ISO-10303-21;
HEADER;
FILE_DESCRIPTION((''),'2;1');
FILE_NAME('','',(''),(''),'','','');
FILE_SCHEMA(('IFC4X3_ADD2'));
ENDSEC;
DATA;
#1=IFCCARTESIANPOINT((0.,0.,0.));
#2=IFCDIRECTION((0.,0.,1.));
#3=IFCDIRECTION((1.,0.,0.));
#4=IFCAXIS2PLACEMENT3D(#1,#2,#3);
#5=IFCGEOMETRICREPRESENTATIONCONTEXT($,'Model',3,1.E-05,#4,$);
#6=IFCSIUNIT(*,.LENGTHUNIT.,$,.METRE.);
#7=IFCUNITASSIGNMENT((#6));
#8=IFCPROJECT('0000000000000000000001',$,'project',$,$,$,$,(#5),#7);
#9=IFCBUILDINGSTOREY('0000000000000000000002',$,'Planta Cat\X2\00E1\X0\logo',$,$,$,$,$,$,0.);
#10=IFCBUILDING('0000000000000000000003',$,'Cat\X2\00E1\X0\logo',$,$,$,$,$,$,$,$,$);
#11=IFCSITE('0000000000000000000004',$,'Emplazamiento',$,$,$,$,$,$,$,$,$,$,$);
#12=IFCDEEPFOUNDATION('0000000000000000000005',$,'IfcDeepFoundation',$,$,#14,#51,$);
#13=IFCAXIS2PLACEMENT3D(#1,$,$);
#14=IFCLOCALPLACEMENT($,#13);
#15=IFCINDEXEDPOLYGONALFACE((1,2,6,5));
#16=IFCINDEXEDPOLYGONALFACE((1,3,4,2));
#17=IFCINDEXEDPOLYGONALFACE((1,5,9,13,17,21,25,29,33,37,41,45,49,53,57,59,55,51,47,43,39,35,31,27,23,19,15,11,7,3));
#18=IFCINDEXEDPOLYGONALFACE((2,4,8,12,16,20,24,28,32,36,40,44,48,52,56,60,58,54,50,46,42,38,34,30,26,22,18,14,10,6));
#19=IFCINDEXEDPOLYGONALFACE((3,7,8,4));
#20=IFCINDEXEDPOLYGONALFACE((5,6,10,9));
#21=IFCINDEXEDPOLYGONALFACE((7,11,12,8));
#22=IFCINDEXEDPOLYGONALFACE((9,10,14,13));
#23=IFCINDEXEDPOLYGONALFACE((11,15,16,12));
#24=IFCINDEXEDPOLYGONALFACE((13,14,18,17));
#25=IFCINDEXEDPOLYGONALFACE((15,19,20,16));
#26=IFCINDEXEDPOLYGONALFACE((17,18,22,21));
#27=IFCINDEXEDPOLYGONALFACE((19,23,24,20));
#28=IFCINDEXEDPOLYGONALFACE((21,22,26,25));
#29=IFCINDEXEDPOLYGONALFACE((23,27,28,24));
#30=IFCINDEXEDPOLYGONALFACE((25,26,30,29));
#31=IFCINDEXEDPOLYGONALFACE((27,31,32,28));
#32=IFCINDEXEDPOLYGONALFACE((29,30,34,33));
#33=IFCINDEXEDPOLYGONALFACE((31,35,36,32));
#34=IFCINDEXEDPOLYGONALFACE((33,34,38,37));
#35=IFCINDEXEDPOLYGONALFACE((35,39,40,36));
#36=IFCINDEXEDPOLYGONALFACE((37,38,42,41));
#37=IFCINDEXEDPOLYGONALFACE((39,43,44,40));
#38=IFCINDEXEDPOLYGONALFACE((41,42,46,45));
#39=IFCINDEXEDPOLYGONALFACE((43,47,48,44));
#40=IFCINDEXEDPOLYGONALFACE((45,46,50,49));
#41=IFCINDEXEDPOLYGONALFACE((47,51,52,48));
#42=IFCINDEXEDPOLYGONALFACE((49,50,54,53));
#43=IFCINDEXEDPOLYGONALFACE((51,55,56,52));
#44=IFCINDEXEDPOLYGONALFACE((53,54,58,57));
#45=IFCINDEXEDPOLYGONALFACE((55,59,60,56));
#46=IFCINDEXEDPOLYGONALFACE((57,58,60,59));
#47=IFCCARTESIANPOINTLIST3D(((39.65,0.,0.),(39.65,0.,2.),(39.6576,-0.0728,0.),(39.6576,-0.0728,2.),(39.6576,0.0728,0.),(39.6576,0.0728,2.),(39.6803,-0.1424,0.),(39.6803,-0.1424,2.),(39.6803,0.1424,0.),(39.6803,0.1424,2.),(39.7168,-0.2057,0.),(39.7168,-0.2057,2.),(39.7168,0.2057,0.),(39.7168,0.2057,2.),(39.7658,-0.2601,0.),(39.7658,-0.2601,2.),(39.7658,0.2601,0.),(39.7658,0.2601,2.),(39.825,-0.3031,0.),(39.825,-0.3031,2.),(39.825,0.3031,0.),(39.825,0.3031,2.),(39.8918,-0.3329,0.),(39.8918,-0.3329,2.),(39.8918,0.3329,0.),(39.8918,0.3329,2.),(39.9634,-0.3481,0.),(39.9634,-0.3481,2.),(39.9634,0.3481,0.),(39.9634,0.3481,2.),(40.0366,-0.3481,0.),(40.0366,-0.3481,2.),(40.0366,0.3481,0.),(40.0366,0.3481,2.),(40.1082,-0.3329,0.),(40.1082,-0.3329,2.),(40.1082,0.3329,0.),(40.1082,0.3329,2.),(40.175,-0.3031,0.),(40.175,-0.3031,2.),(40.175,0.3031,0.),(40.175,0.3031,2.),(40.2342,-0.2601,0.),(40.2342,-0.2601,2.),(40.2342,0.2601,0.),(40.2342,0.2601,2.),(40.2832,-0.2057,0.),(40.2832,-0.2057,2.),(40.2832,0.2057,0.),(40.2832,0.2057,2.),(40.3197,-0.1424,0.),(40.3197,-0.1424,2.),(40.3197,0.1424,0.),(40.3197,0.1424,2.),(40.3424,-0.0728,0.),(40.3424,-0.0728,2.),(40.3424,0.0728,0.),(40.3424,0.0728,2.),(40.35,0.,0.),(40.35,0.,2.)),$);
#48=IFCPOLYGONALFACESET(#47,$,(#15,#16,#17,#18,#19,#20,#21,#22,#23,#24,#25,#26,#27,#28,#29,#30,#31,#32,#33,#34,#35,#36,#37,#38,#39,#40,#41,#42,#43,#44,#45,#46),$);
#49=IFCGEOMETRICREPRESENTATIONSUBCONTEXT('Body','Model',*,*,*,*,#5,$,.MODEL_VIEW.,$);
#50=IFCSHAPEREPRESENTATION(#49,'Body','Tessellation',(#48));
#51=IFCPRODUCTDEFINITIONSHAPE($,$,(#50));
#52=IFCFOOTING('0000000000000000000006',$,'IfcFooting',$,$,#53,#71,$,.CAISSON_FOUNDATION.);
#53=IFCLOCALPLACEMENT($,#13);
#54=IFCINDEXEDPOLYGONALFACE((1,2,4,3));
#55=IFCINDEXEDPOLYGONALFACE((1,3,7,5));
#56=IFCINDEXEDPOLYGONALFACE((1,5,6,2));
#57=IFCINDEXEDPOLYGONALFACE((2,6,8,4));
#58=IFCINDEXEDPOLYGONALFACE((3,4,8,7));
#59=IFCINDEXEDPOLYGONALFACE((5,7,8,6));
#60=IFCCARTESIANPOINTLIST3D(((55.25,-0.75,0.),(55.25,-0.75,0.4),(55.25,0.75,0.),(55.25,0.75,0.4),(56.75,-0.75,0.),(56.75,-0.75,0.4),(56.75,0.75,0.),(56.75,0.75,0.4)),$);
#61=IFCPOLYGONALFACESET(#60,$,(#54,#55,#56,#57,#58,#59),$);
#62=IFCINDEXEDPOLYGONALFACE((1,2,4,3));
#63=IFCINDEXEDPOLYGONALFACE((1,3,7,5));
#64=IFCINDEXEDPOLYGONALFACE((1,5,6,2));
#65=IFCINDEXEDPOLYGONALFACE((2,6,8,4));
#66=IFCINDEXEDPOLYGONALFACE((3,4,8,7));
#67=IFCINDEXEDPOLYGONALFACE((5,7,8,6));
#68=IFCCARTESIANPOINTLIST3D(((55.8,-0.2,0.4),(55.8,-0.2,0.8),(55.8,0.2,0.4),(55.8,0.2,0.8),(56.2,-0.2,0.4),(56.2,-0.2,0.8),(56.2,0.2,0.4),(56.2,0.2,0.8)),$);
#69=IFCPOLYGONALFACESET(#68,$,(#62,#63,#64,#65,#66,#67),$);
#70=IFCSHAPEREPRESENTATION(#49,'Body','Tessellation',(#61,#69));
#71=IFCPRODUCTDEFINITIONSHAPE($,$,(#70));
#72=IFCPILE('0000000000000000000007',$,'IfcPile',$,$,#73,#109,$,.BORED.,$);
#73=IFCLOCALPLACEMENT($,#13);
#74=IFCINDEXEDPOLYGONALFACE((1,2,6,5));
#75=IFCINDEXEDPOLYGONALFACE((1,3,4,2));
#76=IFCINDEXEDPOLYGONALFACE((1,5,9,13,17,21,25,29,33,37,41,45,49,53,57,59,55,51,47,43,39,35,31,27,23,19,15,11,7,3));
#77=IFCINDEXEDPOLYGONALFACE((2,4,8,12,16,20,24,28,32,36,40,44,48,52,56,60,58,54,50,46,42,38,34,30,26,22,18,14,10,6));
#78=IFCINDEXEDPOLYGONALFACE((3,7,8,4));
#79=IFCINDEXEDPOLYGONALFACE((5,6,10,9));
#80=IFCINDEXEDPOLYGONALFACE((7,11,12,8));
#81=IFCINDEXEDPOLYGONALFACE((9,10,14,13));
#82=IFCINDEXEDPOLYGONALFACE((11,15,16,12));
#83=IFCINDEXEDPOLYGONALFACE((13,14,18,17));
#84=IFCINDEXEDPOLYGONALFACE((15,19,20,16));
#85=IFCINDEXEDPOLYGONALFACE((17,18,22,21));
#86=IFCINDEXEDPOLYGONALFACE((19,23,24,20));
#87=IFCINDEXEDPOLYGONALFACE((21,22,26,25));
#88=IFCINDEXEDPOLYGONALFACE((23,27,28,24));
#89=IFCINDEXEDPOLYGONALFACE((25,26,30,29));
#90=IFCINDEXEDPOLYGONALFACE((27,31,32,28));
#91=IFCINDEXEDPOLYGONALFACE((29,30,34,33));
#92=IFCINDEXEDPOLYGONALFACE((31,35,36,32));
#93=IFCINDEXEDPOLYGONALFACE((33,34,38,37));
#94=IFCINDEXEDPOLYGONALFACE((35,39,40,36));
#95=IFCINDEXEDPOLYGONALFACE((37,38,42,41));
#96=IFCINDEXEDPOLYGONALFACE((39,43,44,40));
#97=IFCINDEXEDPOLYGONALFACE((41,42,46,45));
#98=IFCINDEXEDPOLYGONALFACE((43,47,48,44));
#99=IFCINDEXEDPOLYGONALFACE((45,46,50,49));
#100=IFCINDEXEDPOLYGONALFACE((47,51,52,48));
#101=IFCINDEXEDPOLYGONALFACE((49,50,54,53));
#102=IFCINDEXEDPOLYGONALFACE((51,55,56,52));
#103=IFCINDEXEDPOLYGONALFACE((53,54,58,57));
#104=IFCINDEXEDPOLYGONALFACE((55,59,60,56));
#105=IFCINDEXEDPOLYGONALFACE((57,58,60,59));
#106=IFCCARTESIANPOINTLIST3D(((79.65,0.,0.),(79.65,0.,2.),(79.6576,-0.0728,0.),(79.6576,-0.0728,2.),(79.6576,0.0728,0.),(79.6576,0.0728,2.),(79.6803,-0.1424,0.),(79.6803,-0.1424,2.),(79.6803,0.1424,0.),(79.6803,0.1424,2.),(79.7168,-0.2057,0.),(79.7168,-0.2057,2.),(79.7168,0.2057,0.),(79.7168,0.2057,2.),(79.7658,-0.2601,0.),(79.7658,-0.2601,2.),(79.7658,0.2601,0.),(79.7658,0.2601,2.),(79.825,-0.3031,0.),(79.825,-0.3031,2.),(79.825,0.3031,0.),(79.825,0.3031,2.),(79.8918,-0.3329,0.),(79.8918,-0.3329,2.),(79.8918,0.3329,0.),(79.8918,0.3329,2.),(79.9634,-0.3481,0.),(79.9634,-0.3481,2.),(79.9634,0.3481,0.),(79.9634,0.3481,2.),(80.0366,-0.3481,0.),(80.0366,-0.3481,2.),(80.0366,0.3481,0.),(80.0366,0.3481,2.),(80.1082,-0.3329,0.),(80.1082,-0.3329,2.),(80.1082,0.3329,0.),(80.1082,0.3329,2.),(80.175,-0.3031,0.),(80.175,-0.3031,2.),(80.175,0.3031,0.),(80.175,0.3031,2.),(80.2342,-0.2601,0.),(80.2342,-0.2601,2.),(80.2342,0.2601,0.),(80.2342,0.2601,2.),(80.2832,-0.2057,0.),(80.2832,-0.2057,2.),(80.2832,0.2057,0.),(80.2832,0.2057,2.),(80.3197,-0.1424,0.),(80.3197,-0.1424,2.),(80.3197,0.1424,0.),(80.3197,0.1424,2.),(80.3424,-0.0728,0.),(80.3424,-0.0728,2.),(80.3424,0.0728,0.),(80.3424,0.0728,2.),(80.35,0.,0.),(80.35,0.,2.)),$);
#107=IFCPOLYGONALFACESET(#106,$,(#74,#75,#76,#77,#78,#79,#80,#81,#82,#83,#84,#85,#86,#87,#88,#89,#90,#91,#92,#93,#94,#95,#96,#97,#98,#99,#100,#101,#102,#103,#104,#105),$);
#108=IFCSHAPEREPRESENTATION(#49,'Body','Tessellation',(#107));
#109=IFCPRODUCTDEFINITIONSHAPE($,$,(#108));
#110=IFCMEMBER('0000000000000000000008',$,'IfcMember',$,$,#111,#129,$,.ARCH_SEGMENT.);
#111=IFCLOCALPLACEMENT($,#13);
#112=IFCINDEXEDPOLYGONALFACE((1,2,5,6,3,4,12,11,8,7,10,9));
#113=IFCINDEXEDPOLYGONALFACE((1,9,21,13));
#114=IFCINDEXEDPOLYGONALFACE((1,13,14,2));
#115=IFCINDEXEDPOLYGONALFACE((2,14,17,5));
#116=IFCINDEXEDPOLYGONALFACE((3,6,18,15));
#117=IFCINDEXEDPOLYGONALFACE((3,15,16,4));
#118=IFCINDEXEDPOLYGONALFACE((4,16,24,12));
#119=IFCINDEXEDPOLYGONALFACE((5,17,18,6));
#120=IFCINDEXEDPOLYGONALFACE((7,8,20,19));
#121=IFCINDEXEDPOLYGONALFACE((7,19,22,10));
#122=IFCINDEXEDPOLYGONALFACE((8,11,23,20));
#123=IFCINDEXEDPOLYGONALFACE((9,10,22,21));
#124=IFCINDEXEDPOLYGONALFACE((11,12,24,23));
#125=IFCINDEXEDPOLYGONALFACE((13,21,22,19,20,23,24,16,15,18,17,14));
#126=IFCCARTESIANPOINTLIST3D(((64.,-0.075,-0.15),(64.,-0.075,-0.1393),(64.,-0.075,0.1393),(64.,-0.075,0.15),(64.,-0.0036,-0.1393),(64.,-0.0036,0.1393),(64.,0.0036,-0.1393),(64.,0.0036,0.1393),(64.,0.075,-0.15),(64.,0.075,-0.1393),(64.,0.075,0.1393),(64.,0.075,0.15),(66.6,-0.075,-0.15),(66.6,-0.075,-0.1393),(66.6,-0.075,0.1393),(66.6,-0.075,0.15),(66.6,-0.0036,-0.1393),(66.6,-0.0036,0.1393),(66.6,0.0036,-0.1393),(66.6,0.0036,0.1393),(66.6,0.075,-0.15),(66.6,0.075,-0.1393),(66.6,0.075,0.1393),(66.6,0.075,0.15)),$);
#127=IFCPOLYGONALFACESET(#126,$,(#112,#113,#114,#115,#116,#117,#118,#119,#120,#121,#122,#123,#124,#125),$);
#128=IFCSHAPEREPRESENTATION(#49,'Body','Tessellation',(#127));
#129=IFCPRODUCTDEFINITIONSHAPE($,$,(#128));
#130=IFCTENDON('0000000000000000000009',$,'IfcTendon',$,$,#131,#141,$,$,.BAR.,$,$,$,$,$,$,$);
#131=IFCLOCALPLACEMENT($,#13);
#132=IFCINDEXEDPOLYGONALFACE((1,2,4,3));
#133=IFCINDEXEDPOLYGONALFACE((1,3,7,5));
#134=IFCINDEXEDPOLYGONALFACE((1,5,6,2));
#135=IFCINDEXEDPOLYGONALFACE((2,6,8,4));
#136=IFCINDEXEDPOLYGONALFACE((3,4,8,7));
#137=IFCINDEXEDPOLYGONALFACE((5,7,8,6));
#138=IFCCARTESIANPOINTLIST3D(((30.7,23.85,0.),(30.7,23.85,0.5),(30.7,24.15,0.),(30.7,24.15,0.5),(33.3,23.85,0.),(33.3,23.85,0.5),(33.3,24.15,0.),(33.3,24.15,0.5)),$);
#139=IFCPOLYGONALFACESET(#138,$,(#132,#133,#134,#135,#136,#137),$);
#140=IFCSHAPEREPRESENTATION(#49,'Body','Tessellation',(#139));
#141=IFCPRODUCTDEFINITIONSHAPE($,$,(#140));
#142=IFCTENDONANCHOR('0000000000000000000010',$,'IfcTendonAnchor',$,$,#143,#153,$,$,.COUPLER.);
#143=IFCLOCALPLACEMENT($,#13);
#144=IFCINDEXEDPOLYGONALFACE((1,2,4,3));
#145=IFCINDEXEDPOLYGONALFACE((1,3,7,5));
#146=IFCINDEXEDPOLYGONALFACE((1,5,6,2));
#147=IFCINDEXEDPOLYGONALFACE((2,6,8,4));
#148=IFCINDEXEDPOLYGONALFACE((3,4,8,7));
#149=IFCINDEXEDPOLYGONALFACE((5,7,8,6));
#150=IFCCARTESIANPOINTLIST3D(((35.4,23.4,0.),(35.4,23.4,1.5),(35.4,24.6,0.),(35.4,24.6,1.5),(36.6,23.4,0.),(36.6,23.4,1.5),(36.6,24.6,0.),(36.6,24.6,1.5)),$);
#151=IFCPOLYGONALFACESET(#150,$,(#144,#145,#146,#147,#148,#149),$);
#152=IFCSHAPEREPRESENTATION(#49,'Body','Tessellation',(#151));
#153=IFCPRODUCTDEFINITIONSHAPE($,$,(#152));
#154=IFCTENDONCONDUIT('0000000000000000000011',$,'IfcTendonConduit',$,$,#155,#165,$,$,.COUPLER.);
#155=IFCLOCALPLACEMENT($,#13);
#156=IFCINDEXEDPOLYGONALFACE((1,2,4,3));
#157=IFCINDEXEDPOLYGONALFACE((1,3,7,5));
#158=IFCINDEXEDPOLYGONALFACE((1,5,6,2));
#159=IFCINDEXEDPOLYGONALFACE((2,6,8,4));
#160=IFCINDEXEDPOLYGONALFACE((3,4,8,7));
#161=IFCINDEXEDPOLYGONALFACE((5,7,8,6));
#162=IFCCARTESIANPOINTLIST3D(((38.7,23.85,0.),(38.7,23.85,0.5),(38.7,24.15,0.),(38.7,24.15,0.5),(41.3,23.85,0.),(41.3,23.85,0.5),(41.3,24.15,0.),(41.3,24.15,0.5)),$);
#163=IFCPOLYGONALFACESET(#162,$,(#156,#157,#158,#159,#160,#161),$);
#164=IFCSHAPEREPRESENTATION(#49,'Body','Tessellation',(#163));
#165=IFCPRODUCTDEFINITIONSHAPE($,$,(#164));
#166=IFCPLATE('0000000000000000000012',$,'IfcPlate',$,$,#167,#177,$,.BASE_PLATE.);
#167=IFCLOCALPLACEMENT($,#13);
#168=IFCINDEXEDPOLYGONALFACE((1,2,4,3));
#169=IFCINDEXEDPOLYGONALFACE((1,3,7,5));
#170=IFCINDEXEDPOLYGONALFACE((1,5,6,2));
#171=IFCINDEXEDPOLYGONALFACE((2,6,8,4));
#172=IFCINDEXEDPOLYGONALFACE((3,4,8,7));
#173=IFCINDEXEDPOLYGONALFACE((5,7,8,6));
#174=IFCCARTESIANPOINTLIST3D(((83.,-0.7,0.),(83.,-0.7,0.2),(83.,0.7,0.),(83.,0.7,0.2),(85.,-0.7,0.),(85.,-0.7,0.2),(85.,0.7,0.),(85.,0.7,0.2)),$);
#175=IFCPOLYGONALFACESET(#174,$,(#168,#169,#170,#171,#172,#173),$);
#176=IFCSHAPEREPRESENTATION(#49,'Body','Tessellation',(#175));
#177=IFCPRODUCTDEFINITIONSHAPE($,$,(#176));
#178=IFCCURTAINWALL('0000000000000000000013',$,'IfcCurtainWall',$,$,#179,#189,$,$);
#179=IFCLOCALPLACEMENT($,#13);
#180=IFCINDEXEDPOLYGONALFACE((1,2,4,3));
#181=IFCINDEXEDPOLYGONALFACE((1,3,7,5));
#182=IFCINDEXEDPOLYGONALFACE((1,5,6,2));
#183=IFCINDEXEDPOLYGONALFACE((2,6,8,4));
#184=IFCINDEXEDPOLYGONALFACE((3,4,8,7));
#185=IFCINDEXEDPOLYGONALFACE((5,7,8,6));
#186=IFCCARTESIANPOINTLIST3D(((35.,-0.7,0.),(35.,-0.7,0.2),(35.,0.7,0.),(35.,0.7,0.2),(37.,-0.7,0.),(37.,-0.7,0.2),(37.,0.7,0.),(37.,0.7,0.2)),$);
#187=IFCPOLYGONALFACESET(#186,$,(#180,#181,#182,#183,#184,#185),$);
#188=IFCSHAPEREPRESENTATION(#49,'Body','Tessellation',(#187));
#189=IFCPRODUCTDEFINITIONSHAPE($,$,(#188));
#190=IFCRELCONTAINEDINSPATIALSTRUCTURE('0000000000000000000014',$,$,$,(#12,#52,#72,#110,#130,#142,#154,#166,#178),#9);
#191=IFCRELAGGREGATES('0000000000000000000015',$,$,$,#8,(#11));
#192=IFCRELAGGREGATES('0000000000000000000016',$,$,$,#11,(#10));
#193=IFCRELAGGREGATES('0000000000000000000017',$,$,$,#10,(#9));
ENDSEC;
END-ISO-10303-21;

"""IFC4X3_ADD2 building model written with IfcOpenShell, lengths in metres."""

from ifc_helpers import new_model, si_unit, frame, origin, origin_with_axes, origin_2d, place, context, subcontext, project, spatial, rectangle, circle, i_section, extrude, element, save


model = new_model("IFC4X3_ADD2")

# Units and contexts
model_context = context("Model", 3, precision=1e-05, world=origin_with_axes())
body_context = subcontext(model_context, "Body", "Model", "MODEL_VIEW")
ifc_project = project(units=[si_unit("LENGTHUNIT", "METRE")], contexts=[model_context])

# Site, building, storey
site = spatial("IfcSite", under=ifc_project, Name="Emplazamiento")
building = spatial("IfcBuilding", under=site, Name="Catálogo")
storey = spatial("IfcBuildingStorey", under=building, Name="Planta Catálogo", Elevation=0.0)

# Deep foundation
deep_foundation_placement = place(None, frame((40.0, 0.0, 0.0), z_axis=(0.0, 0.0, 1.0), x_axis=(1.0, 0.0, 0.0)))
element("IfcDeepFoundation", 1, at=deep_foundation_placement, inside=storey, Name="IfcDeepFoundation", context=body_context, shape_type="SweptSolid", body=[
    extrude(circle(Radius=0.35, at=origin_2d()), origin(), (0.0, 0.0, 1.0), 2.0),
])

# Footing
footing_placement = place(None, frame((56.0, 0.0, 0.0), z_axis=(0.0, 0.0, 1.0), x_axis=(1.0, 0.0, 0.0)))
element("IfcFooting", 2, at=footing_placement, inside=storey, Name="IfcFooting", PredefinedType="CAISSON_FOUNDATION", context=body_context, shape_type="SweptSolid", body=[
    extrude(rectangle(XDim=1.5, YDim=1.5, at=origin_2d()), origin(), (0.0, 0.0, 1.0), 0.4),
    extrude(rectangle(XDim=0.4, YDim=0.4, at=origin_2d()), frame((0.0, 0.0, 0.4)), (0.0, 0.0, 1.0), 0.4),
])

# Pile
pile_placement = place(None, frame((80.0, 0.0, 0.0), z_axis=(0.0, 0.0, 1.0), x_axis=(1.0, 0.0, 0.0)))
element("IfcPile", 3, at=pile_placement, inside=storey, Name="IfcPile", PredefinedType="BORED", context=body_context, shape_type="SweptSolid", body=[
    extrude(circle(Radius=0.35, at=origin_2d()), origin(), (0.0, 0.0, 1.0), 2.0),
])

# Member
member_placement = place(None, frame((64.0, 0.0, 0.0), z_axis=(1.0, 0.0, 0.0), x_axis=(0.0, 1.0, 0.0)))
element("IfcMember", 4, at=member_placement, inside=storey, Name="IfcMember", PredefinedType="ARCH_SEGMENT", context=body_context, shape_type="SweptSolid", body=[
    extrude(i_section(OverallWidth=0.15, OverallDepth=0.3, WebThickness=0.0071, FlangeThickness=0.0107, at=origin_2d()), origin(), (0.0, 0.0, 1.0), 2.6),
])

# Tendon
tendon_placement = place(None, frame((32.0, 24.0, 0.0), z_axis=(0.0, 0.0, 1.0), x_axis=(1.0, 0.0, 0.0)))
element("IfcTendon", 5, at=tendon_placement, inside=storey, Name="IfcTendon", PredefinedType="BAR", context=body_context, shape_type="SweptSolid", body=[
    extrude(rectangle(XDim=2.6, YDim=0.3, at=origin_2d()), origin(), (0.0, 0.0, 1.0), 0.5),
])

# Tendon anchor
tendon_anchor_placement = place(None, frame((36.0, 24.0, 0.0), z_axis=(0.0, 0.0, 1.0), x_axis=(1.0, 0.0, 0.0)))
element("IfcTendonAnchor", 6, at=tendon_anchor_placement, inside=storey, Name="IfcTendonAnchor", PredefinedType="COUPLER", context=body_context, shape_type="SweptSolid", body=[
    extrude(rectangle(XDim=1.2, YDim=1.2, at=origin_2d()), origin(), (0.0, 0.0, 1.0), 1.5),
])

# Tendon conduit
tendon_conduit_placement = place(None, frame((40.0, 24.0, 0.0), z_axis=(0.0, 0.0, 1.0), x_axis=(1.0, 0.0, 0.0)))
element("IfcTendonConduit", 7, at=tendon_conduit_placement, inside=storey, Name="IfcTendonConduit", PredefinedType="COUPLER", context=body_context, shape_type="SweptSolid", body=[
    extrude(rectangle(XDim=2.6, YDim=0.3, at=origin_2d()), origin(), (0.0, 0.0, 1.0), 0.5),
])

# Plate
plate_placement = place(None, frame((84.0, 0.0, 0.0), z_axis=(0.0, 0.0, 1.0), x_axis=(1.0, 0.0, 0.0)))
element("IfcPlate", 8, at=plate_placement, inside=storey, Name="IfcPlate", PredefinedType="BASE_PLATE", context=body_context, shape_type="SweptSolid", body=[
    extrude(rectangle(XDim=2.0, YDim=1.4, at=origin_2d()), origin(), (0.0, 0.0, 1.0), 0.2),
])

# Curtain wall
curtain_wall_placement = place(None, frame((36.0, 0.0, 0.0), z_axis=(0.0, 0.0, 1.0), x_axis=(1.0, 0.0, 0.0)))
element("IfcCurtainWall", 9, at=curtain_wall_placement, inside=storey, Name="IfcCurtainWall", context=body_context, shape_type="SweptSolid", body=[
    extrude(rectangle(XDim=2.0, YDim=1.4, at=origin_2d()), origin(), (0.0, 0.0, 1.0), 0.2),
])

save(model, "model.ifc")
